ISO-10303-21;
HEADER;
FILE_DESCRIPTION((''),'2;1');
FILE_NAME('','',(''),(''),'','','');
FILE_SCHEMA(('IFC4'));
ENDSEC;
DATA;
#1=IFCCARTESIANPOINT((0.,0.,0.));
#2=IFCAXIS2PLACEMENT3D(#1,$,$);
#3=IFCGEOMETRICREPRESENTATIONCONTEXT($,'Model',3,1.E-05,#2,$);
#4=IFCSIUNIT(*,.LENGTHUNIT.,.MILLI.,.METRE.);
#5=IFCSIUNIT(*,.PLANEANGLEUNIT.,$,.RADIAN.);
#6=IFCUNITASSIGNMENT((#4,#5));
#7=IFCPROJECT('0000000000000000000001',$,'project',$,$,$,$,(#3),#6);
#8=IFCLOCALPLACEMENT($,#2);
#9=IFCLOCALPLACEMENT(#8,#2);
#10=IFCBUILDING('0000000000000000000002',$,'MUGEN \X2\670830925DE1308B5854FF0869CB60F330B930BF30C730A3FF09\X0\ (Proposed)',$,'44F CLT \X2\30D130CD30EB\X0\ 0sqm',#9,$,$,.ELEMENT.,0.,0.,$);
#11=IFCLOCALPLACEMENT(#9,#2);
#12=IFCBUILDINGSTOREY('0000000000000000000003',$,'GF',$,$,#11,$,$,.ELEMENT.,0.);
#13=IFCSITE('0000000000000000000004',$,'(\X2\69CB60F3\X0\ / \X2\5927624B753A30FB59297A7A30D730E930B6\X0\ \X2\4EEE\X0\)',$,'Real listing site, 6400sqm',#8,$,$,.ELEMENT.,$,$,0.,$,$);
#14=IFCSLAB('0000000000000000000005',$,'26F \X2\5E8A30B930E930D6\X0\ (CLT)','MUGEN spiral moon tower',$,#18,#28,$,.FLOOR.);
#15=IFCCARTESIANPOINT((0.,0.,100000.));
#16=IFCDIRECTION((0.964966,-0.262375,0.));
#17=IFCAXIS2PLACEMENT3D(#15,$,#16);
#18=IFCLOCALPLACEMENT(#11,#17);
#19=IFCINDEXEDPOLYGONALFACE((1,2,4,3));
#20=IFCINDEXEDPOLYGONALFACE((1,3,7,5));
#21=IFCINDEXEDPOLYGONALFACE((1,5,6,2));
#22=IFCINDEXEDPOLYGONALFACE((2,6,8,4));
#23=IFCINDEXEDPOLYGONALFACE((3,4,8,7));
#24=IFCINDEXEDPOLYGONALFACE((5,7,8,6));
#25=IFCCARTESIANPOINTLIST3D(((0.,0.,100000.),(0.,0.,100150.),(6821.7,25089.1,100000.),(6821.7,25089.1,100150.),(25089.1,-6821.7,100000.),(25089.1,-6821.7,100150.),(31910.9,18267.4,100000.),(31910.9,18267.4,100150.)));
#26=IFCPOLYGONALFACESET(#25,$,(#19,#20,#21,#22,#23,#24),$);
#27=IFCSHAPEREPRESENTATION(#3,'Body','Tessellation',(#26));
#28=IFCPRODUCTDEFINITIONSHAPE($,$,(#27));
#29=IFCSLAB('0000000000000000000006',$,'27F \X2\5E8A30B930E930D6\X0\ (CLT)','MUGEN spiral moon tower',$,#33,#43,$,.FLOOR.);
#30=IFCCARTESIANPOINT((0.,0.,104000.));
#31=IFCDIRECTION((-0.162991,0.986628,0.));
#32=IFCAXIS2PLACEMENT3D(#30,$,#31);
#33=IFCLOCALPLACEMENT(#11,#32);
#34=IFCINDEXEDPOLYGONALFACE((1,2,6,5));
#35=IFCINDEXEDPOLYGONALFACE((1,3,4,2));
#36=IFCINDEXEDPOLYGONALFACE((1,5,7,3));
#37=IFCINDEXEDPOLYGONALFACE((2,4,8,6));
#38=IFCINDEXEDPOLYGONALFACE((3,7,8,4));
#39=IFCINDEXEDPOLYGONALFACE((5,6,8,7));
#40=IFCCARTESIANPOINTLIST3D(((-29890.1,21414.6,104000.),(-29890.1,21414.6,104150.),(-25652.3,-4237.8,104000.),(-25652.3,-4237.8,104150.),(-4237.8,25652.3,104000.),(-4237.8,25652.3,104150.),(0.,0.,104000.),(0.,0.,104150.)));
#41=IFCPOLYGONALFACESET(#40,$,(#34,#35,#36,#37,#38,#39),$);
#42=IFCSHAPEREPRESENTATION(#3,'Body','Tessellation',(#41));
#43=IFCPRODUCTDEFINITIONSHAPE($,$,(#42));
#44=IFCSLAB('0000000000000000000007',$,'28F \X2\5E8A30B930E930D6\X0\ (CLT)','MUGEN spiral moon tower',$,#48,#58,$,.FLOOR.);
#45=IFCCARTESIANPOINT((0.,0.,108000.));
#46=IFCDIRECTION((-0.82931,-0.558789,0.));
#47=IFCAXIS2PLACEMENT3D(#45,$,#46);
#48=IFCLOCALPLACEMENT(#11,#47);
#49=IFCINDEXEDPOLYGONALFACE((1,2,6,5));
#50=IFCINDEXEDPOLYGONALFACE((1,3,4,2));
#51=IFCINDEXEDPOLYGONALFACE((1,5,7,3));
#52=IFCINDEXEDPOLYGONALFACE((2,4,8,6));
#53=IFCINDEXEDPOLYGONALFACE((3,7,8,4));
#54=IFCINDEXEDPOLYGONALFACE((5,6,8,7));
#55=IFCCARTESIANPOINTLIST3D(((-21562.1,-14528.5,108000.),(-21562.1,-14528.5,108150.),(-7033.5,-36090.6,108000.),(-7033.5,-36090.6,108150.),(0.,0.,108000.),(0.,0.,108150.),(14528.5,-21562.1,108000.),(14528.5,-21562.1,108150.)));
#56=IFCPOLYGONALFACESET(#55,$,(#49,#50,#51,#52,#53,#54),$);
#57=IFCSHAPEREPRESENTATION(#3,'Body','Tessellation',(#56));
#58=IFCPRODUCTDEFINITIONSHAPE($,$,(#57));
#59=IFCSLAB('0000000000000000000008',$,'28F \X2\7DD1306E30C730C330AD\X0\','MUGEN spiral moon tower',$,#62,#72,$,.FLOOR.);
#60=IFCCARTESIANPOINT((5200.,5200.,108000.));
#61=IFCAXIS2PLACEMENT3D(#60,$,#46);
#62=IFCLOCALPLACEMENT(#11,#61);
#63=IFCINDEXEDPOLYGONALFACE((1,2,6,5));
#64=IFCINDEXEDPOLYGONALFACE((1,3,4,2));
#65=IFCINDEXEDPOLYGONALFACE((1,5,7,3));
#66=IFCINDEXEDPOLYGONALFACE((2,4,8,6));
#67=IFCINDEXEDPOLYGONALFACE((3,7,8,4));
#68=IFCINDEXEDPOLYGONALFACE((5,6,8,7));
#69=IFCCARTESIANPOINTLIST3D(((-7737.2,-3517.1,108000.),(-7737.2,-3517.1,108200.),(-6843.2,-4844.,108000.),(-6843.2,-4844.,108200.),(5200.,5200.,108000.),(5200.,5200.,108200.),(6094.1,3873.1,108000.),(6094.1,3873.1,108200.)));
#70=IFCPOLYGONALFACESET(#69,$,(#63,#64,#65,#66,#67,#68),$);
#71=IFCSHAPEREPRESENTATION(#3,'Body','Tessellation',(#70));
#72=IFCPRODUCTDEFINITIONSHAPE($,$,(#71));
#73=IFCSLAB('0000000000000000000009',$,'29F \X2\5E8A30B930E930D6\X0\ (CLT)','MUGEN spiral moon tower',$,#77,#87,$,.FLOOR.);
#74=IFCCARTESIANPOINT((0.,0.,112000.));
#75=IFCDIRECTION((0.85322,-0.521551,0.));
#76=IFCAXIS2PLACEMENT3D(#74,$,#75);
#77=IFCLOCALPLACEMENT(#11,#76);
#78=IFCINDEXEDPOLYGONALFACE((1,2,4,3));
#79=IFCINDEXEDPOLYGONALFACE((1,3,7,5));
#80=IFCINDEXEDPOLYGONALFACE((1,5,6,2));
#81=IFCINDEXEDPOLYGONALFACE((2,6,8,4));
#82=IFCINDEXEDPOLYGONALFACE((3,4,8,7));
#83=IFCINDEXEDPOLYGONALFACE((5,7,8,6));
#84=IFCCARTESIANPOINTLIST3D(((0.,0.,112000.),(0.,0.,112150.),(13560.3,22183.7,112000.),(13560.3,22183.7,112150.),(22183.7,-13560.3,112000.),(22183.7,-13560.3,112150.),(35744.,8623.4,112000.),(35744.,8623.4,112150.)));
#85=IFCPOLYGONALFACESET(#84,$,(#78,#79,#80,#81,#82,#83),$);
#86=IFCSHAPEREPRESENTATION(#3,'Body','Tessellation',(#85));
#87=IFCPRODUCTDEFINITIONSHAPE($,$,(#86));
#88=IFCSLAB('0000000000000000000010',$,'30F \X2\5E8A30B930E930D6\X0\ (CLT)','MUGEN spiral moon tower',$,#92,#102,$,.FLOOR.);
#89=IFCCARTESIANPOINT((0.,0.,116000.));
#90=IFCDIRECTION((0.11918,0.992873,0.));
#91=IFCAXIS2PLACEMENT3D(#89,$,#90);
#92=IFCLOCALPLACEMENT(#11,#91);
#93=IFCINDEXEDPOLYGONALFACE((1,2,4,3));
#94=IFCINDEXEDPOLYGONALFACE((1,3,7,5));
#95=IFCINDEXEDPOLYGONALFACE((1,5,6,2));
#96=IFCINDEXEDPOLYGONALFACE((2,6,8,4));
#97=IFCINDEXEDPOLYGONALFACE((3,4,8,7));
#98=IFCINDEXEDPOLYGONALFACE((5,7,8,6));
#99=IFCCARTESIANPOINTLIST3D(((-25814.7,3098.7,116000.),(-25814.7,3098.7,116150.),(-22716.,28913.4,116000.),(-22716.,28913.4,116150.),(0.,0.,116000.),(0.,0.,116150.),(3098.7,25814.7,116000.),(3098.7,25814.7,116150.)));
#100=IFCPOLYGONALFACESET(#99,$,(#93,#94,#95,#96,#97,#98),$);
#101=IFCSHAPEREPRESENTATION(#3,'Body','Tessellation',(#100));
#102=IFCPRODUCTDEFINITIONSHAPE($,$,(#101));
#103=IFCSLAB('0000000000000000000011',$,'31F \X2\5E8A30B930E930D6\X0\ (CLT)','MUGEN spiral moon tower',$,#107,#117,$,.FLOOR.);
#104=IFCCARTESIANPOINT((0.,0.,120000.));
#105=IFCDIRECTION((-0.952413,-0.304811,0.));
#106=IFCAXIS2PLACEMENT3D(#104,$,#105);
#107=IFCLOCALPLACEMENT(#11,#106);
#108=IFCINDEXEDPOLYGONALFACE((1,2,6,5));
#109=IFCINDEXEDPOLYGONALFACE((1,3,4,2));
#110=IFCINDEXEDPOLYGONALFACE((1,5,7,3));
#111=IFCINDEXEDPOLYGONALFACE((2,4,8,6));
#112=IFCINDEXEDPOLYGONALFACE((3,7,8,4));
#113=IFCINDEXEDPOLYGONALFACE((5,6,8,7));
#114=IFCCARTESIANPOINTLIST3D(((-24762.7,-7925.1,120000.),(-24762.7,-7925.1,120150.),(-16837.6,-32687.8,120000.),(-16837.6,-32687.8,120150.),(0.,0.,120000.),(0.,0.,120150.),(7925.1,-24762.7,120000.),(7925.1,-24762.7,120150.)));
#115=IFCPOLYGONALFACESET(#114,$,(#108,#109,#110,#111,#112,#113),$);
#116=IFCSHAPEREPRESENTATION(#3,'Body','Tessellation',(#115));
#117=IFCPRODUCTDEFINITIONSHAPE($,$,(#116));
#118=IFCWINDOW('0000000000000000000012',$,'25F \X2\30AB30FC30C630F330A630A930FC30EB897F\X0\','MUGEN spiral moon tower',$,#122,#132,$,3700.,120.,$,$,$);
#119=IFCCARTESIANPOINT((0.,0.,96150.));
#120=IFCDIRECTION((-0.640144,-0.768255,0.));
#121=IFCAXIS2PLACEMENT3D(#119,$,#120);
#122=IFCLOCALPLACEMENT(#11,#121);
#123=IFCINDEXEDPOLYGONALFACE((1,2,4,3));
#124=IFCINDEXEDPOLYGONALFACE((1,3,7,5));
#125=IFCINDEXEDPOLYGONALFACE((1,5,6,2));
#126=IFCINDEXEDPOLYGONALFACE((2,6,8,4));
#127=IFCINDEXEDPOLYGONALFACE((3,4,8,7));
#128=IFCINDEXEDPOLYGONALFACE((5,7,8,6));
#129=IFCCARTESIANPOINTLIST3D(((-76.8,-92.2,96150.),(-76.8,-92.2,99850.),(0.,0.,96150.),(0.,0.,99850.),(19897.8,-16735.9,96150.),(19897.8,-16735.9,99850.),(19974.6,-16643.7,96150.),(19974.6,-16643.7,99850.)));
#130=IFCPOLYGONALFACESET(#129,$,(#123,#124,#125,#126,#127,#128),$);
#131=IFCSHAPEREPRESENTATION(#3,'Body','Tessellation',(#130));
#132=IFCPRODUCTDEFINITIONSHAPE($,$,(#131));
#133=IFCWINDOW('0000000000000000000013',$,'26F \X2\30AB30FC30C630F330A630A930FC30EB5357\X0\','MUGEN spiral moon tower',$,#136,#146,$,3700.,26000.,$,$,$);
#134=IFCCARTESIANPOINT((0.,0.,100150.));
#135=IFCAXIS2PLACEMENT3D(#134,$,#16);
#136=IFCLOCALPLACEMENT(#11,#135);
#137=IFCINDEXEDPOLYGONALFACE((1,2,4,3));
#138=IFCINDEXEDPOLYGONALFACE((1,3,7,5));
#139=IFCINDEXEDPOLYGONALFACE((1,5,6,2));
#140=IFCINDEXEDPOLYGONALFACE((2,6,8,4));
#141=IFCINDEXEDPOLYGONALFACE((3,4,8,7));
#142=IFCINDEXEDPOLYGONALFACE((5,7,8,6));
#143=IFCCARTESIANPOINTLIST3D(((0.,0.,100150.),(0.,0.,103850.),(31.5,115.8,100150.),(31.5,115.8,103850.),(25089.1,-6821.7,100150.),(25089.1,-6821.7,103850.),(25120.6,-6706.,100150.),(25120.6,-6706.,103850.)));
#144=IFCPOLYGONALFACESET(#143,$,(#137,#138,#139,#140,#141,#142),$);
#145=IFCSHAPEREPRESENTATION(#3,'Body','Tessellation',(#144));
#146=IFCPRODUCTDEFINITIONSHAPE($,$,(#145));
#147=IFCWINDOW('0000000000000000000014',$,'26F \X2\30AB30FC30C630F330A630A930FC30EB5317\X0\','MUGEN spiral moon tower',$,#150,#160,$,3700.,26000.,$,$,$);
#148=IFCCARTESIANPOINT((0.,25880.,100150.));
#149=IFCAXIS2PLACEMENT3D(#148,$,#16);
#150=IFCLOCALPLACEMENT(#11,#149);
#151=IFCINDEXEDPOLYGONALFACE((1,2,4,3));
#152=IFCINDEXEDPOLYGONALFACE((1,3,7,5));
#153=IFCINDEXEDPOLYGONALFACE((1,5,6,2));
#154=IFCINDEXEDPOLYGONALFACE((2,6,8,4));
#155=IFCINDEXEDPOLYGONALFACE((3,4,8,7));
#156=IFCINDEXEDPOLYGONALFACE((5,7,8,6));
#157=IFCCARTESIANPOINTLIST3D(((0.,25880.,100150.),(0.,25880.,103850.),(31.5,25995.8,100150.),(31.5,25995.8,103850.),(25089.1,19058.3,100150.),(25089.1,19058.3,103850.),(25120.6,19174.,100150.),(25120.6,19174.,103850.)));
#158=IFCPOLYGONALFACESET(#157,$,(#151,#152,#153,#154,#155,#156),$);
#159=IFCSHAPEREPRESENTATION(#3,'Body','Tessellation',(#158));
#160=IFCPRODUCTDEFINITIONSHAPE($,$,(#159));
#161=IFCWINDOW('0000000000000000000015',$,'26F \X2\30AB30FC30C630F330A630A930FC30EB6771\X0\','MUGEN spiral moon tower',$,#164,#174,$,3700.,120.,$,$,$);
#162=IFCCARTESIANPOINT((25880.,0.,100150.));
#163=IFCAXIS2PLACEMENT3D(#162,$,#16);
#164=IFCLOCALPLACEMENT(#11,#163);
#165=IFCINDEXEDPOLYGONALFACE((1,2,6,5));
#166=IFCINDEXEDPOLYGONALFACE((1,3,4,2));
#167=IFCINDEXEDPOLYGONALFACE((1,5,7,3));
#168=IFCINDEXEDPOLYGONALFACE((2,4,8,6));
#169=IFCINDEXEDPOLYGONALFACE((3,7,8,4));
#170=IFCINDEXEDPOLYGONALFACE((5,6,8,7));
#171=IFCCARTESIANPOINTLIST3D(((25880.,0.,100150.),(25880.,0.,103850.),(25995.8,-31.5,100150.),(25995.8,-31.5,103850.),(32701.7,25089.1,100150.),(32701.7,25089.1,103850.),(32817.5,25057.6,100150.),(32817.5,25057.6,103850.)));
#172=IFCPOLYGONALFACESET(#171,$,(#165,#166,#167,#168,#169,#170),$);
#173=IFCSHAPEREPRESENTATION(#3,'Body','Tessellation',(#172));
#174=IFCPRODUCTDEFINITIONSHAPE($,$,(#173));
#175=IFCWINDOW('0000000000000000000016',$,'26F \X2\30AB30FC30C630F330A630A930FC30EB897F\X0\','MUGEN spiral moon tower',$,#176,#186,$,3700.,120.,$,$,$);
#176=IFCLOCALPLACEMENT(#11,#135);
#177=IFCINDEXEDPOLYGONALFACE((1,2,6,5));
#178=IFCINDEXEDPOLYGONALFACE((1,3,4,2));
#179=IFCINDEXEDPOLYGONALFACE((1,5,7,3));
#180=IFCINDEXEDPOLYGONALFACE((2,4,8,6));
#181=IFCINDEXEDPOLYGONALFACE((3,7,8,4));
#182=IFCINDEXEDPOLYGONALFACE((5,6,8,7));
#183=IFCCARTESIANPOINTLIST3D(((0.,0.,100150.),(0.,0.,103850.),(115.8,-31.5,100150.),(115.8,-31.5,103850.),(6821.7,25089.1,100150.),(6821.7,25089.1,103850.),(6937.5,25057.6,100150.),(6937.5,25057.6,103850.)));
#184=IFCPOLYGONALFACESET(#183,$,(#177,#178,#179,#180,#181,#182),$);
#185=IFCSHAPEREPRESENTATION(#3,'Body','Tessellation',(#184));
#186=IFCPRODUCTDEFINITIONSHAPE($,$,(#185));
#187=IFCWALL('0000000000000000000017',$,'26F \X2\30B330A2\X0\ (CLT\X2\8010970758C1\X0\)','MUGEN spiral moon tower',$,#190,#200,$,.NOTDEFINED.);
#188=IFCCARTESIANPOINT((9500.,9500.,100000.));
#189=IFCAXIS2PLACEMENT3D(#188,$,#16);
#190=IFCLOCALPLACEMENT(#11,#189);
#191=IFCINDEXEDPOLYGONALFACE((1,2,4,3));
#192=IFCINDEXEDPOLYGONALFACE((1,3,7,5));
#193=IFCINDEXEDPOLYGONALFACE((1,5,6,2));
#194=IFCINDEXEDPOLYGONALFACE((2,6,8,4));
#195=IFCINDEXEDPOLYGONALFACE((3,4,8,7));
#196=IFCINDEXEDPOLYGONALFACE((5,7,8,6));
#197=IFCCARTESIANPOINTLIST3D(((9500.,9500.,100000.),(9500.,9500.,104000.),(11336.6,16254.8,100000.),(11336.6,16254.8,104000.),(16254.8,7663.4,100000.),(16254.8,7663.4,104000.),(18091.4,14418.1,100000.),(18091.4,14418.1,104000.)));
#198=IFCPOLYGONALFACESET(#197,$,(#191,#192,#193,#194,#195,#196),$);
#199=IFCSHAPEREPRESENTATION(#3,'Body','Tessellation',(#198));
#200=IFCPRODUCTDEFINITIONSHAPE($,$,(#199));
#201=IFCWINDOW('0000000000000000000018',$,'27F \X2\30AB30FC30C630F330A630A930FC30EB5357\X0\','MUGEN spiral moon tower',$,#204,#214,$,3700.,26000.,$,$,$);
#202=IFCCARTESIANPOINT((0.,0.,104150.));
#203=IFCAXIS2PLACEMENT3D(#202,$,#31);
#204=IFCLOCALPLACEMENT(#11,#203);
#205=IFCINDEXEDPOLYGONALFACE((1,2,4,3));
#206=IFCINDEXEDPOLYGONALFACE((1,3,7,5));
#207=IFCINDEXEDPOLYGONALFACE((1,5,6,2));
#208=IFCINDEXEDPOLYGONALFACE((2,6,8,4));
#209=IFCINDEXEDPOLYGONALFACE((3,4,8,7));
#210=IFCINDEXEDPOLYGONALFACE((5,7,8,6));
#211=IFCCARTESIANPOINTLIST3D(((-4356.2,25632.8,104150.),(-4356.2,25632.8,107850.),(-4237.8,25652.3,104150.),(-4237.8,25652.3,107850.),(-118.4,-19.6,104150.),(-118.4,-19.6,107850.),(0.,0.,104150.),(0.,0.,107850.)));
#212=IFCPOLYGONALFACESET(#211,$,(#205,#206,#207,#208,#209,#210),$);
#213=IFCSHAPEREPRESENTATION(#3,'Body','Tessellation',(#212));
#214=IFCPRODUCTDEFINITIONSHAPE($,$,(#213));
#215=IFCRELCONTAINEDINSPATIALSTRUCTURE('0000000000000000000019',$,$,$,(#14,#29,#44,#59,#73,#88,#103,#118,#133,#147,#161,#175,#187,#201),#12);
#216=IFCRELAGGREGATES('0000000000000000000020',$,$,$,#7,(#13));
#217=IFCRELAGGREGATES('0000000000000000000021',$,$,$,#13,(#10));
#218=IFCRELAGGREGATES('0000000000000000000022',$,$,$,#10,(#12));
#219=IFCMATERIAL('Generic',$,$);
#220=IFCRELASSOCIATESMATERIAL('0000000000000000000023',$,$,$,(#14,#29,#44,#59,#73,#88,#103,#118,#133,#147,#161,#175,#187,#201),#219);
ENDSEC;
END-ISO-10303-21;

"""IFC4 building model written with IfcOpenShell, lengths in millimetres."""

from ifc_helpers import new_model, si_unit, frame, frame_2d, origin, place, context, project, spatial, rectangle, extrude, material, element, save


model = new_model("IFC4")

# Units and contexts
model_context = context("Model", 3, precision=1e-05, world=origin())
ifc_project = project(units=[si_unit("LENGTHUNIT", "METRE", prefix="MILLI"), si_unit("PLANEANGLEUNIT", "RADIAN")], contexts=[model_context])

# Site, building, storey
site_placement = place(None, origin())
site = spatial("IfcSite", under=ifc_project, at=site_placement, Name="(構想 / 大手町・天空プラザ 仮)", ObjectType="Real listing site, 6400sqm", CompositionType="ELEMENT", RefElevation=0.0)
building_placement = place(site_placement, origin())
building = spatial("IfcBuilding", under=site, at=building_placement, Name="MUGEN 月を巡る塔（構想スタディ） (Proposed)", ObjectType="44F CLT パネル 0sqm", CompositionType="ELEMENT", ElevationOfRefHeight=0.0, ElevationOfTerrain=0.0)
storey_placement = place(building_placement, origin())
storey = spatial("IfcBuildingStorey", under=building, at=storey_placement, Name="GF", CompositionType="ELEMENT", Elevation=0.0)

# Slabs
ifc_material = material(Name="Generic")
slab_1_placement = place(storey_placement, frame((0.0, 0.0, 100000.0), x_axis=(0.964966, -0.262375, 0.0)))
element("IfcSlab", 1, at=slab_1_placement, inside=storey, material=ifc_material, Name="26F 床スラブ (CLT)", Description="MUGEN spiral moon tower", PredefinedType="FLOOR", context=model_context, shape_type="SweptSolid", body=[
    extrude(rectangle(XDim=26000.0, YDim=26000.0, at=frame_2d((13000.0, 13000.0))), frame((0.0, 0.0, 100000.0), x_axis=(0.964966, -0.262375, 0.0)), (0.0, 0.0, 1.0), 150.0),
])
slab_2_placement = place(storey_placement, frame((0.0, 0.0, 104000.0), x_axis=(-0.162991, 0.986628, 0.0)))
element("IfcSlab", 2, at=slab_2_placement, inside=storey, material=ifc_material, Name="27F 床スラブ (CLT)", Description="MUGEN spiral moon tower", PredefinedType="FLOOR", context=model_context, shape_type="SweptSolid", body=[
    extrude(rectangle(XDim=26000.0, YDim=26000.0, at=frame_2d((13000.0, 13000.0))), frame((0.0, 0.0, 104000.0), x_axis=(-0.162991, 0.986628, 0.0)), (0.0, 0.0, 1.0), 150.0),
])
slab_3_placement = place(storey_placement, frame((0.0, 0.0, 108000.0), x_axis=(-0.82931, -0.558789, 0.0)))
element("IfcSlab", 3, at=slab_3_placement, inside=storey, material=ifc_material, Name="28F 床スラブ (CLT)", Description="MUGEN spiral moon tower", PredefinedType="FLOOR", context=model_context, shape_type="SweptSolid", body=[
    extrude(rectangle(XDim=26000.0, YDim=26000.0, at=frame_2d((13000.0, 13000.0))), frame((0.0, 0.0, 108000.0), x_axis=(-0.82931, -0.558789, 0.0)), (0.0, 0.0, 1.0), 150.0),
])
slab_4_placement = place(storey_placement, frame((5200.0, 5200.0, 108000.0), x_axis=(-0.82931, -0.558789, 0.0)))
element("IfcSlab", 4, at=slab_4_placement, inside=storey, material=ifc_material, Name="28F 緑のデッキ", Description="MUGEN spiral moon tower", PredefinedType="FLOOR", context=model_context, shape_type="SweptSolid", body=[
    extrude(rectangle(XDim=15600.0, YDim=1600.0, at=frame_2d((7800.0, 800.0))), frame((5200.0, 5200.0, 108000.0), x_axis=(-0.82931, -0.558789, 0.0)), (0.0, 0.0, 1.0), 200.0),
])
slab_5_placement = place(storey_placement, frame((0.0, 0.0, 112000.0), x_axis=(0.85322, -0.521551, 0.0)))
element("IfcSlab", 5, at=slab_5_placement, inside=storey, material=ifc_material, Name="29F 床スラブ (CLT)", Description="MUGEN spiral moon tower", PredefinedType="FLOOR", context=model_context, shape_type="SweptSolid", body=[
    extrude(rectangle(XDim=26000.0, YDim=26000.0, at=frame_2d((13000.0, 13000.0))), frame((0.0, 0.0, 112000.0), x_axis=(0.85322, -0.521551, 0.0)), (0.0, 0.0, 1.0), 150.0),
])
slab_6_placement = place(storey_placement, frame((0.0, 0.0, 116000.0), x_axis=(0.11918, 0.992873, 0.0)))
element("IfcSlab", 6, at=slab_6_placement, inside=storey, material=ifc_material, Name="30F 床スラブ (CLT)", Description="MUGEN spiral moon tower", PredefinedType="FLOOR", context=model_context, shape_type="SweptSolid", body=[
    extrude(rectangle(XDim=26000.0, YDim=26000.0, at=frame_2d((13000.0, 13000.0))), frame((0.0, 0.0, 116000.0), x_axis=(0.11918, 0.992873, 0.0)), (0.0, 0.0, 1.0), 150.0),
])
slab_7_placement = place(storey_placement, frame((0.0, 0.0, 120000.0), x_axis=(-0.952413, -0.304811, 0.0)))
element("IfcSlab", 7, at=slab_7_placement, inside=storey, material=ifc_material, Name="31F 床スラブ (CLT)", Description="MUGEN spiral moon tower", PredefinedType="FLOOR", context=model_context, shape_type="SweptSolid", body=[
    extrude(rectangle(XDim=26000.0, YDim=26000.0, at=frame_2d((13000.0, 13000.0))), frame((0.0, 0.0, 120000.0), x_axis=(-0.952413, -0.304811, 0.0)), (0.0, 0.0, 1.0), 150.0),
])

# Windows
window_1_placement = place(storey_placement, frame((0.0, 0.0, 96150.0), x_axis=(-0.640144, -0.768255, 0.0)))
element("IfcWindow", 8, at=window_1_placement, inside=storey, material=ifc_material, Name="25F カーテンウォール西", Description="MUGEN spiral moon tower", OverallHeight=3700.0, OverallWidth=120.0, context=model_context, shape_type="SweptSolid", body=[
    extrude(rectangle(XDim=120.0, YDim=26000.0, at=frame_2d((60.0, 13000.0))), frame((0.0, 0.0, 96150.0), x_axis=(-0.640144, -0.768255, 0.0)), (0.0, 0.0, 1.0), 3700.0),
])
window_2_placement = place(storey_placement, frame((0.0, 0.0, 100150.0), x_axis=(0.964966, -0.262375, 0.0)))
element("IfcWindow", 9, at=window_2_placement, inside=storey, material=ifc_material, Name="26F カーテンウォール南", Description="MUGEN spiral moon tower", OverallHeight=3700.0, OverallWidth=26000.0, context=model_context, shape_type="SweptSolid", body=[
    extrude(rectangle(XDim=26000.0, YDim=120.0, at=frame_2d((13000.0, 60.0))), frame((0.0, 0.0, 100150.0), x_axis=(0.964966, -0.262375, 0.0)), (0.0, 0.0, 1.0), 3700.0),
])
window_3_placement = place(storey_placement, frame((0.0, 25880.0, 100150.0), x_axis=(0.964966, -0.262375, 0.0)))
element("IfcWindow", 10, at=window_3_placement, inside=storey, material=ifc_material, Name="26F カーテンウォール北", Description="MUGEN spiral moon tower", OverallHeight=3700.0, OverallWidth=26000.0, context=model_context, shape_type="SweptSolid", body=[
    extrude(rectangle(XDim=26000.0, YDim=120.0, at=frame_2d((13000.0, 60.0))), frame((0.0, 25880.0, 100150.0), x_axis=(0.964966, -0.262375, 0.0)), (0.0, 0.0, 1.0), 3700.0),
])
window_4_placement = place(storey_placement, frame((25880.0, 0.0, 100150.0), x_axis=(0.964966, -0.262375, 0.0)))
element("IfcWindow", 11, at=window_4_placement, inside=storey, material=ifc_material, Name="26F カーテンウォール東", Description="MUGEN spiral moon tower", OverallHeight=3700.0, OverallWidth=120.0, context=model_context, shape_type="SweptSolid", body=[
    extrude(rectangle(XDim=120.0, YDim=26000.0, at=frame_2d((60.0, 13000.0))), frame((25880.0, 0.0, 100150.0), x_axis=(0.964966, -0.262375, 0.0)), (0.0, 0.0, 1.0), 3700.0),
])
window_5_placement = place(storey_placement, frame((0.0, 0.0, 100150.0), x_axis=(0.964966, -0.262375, 0.0)))
element("IfcWindow", 12, at=window_5_placement, inside=storey, material=ifc_material, Name="26F カーテンウォール西", Description="MUGEN spiral moon tower", OverallHeight=3700.0, OverallWidth=120.0, context=model_context, shape_type="SweptSolid", body=[
    extrude(rectangle(XDim=120.0, YDim=26000.0, at=frame_2d((60.0, 13000.0))), frame((0.0, 0.0, 100150.0), x_axis=(0.964966, -0.262375, 0.0)), (0.0, 0.0, 1.0), 3700.0),
])

# Wall
wall_1_placement = place(storey_placement, frame((9500.0, 9500.0, 100000.0), x_axis=(0.964966, -0.262375, 0.0)))
element("IfcWall", 13, at=wall_1_placement, inside=storey, material=ifc_material, Name="26F コア (CLT耐震壁)", Description="MUGEN spiral moon tower", PredefinedType="NOTDEFINED", context=model_context, shape_type="SweptSolid", body=[
    extrude(rectangle(XDim=7000.0, YDim=7000.0, at=frame_2d((3500.0, 3500.0))), frame((9500.0, 9500.0, 100000.0), x_axis=(0.964966, -0.262375, 0.0)), (0.0, 0.0, 1.0), 4000.0),
])

# Window
window_6_placement = place(storey_placement, frame((0.0, 0.0, 104150.0), x_axis=(-0.162991, 0.986628, 0.0)))
element("IfcWindow", 14, at=window_6_placement, inside=storey, material=ifc_material, Name="27F カーテンウォール南", Description="MUGEN spiral moon tower", OverallHeight=3700.0, OverallWidth=26000.0, context=model_context, shape_type="SweptSolid", body=[
    extrude(rectangle(XDim=26000.0, YDim=120.0, at=frame_2d((13000.0, 60.0))), frame((0.0, 0.0, 104150.0), x_axis=(-0.162991, 0.986628, 0.0)), (0.0, 0.0, 1.0), 3700.0),
])

save(model, "model.ifc")
